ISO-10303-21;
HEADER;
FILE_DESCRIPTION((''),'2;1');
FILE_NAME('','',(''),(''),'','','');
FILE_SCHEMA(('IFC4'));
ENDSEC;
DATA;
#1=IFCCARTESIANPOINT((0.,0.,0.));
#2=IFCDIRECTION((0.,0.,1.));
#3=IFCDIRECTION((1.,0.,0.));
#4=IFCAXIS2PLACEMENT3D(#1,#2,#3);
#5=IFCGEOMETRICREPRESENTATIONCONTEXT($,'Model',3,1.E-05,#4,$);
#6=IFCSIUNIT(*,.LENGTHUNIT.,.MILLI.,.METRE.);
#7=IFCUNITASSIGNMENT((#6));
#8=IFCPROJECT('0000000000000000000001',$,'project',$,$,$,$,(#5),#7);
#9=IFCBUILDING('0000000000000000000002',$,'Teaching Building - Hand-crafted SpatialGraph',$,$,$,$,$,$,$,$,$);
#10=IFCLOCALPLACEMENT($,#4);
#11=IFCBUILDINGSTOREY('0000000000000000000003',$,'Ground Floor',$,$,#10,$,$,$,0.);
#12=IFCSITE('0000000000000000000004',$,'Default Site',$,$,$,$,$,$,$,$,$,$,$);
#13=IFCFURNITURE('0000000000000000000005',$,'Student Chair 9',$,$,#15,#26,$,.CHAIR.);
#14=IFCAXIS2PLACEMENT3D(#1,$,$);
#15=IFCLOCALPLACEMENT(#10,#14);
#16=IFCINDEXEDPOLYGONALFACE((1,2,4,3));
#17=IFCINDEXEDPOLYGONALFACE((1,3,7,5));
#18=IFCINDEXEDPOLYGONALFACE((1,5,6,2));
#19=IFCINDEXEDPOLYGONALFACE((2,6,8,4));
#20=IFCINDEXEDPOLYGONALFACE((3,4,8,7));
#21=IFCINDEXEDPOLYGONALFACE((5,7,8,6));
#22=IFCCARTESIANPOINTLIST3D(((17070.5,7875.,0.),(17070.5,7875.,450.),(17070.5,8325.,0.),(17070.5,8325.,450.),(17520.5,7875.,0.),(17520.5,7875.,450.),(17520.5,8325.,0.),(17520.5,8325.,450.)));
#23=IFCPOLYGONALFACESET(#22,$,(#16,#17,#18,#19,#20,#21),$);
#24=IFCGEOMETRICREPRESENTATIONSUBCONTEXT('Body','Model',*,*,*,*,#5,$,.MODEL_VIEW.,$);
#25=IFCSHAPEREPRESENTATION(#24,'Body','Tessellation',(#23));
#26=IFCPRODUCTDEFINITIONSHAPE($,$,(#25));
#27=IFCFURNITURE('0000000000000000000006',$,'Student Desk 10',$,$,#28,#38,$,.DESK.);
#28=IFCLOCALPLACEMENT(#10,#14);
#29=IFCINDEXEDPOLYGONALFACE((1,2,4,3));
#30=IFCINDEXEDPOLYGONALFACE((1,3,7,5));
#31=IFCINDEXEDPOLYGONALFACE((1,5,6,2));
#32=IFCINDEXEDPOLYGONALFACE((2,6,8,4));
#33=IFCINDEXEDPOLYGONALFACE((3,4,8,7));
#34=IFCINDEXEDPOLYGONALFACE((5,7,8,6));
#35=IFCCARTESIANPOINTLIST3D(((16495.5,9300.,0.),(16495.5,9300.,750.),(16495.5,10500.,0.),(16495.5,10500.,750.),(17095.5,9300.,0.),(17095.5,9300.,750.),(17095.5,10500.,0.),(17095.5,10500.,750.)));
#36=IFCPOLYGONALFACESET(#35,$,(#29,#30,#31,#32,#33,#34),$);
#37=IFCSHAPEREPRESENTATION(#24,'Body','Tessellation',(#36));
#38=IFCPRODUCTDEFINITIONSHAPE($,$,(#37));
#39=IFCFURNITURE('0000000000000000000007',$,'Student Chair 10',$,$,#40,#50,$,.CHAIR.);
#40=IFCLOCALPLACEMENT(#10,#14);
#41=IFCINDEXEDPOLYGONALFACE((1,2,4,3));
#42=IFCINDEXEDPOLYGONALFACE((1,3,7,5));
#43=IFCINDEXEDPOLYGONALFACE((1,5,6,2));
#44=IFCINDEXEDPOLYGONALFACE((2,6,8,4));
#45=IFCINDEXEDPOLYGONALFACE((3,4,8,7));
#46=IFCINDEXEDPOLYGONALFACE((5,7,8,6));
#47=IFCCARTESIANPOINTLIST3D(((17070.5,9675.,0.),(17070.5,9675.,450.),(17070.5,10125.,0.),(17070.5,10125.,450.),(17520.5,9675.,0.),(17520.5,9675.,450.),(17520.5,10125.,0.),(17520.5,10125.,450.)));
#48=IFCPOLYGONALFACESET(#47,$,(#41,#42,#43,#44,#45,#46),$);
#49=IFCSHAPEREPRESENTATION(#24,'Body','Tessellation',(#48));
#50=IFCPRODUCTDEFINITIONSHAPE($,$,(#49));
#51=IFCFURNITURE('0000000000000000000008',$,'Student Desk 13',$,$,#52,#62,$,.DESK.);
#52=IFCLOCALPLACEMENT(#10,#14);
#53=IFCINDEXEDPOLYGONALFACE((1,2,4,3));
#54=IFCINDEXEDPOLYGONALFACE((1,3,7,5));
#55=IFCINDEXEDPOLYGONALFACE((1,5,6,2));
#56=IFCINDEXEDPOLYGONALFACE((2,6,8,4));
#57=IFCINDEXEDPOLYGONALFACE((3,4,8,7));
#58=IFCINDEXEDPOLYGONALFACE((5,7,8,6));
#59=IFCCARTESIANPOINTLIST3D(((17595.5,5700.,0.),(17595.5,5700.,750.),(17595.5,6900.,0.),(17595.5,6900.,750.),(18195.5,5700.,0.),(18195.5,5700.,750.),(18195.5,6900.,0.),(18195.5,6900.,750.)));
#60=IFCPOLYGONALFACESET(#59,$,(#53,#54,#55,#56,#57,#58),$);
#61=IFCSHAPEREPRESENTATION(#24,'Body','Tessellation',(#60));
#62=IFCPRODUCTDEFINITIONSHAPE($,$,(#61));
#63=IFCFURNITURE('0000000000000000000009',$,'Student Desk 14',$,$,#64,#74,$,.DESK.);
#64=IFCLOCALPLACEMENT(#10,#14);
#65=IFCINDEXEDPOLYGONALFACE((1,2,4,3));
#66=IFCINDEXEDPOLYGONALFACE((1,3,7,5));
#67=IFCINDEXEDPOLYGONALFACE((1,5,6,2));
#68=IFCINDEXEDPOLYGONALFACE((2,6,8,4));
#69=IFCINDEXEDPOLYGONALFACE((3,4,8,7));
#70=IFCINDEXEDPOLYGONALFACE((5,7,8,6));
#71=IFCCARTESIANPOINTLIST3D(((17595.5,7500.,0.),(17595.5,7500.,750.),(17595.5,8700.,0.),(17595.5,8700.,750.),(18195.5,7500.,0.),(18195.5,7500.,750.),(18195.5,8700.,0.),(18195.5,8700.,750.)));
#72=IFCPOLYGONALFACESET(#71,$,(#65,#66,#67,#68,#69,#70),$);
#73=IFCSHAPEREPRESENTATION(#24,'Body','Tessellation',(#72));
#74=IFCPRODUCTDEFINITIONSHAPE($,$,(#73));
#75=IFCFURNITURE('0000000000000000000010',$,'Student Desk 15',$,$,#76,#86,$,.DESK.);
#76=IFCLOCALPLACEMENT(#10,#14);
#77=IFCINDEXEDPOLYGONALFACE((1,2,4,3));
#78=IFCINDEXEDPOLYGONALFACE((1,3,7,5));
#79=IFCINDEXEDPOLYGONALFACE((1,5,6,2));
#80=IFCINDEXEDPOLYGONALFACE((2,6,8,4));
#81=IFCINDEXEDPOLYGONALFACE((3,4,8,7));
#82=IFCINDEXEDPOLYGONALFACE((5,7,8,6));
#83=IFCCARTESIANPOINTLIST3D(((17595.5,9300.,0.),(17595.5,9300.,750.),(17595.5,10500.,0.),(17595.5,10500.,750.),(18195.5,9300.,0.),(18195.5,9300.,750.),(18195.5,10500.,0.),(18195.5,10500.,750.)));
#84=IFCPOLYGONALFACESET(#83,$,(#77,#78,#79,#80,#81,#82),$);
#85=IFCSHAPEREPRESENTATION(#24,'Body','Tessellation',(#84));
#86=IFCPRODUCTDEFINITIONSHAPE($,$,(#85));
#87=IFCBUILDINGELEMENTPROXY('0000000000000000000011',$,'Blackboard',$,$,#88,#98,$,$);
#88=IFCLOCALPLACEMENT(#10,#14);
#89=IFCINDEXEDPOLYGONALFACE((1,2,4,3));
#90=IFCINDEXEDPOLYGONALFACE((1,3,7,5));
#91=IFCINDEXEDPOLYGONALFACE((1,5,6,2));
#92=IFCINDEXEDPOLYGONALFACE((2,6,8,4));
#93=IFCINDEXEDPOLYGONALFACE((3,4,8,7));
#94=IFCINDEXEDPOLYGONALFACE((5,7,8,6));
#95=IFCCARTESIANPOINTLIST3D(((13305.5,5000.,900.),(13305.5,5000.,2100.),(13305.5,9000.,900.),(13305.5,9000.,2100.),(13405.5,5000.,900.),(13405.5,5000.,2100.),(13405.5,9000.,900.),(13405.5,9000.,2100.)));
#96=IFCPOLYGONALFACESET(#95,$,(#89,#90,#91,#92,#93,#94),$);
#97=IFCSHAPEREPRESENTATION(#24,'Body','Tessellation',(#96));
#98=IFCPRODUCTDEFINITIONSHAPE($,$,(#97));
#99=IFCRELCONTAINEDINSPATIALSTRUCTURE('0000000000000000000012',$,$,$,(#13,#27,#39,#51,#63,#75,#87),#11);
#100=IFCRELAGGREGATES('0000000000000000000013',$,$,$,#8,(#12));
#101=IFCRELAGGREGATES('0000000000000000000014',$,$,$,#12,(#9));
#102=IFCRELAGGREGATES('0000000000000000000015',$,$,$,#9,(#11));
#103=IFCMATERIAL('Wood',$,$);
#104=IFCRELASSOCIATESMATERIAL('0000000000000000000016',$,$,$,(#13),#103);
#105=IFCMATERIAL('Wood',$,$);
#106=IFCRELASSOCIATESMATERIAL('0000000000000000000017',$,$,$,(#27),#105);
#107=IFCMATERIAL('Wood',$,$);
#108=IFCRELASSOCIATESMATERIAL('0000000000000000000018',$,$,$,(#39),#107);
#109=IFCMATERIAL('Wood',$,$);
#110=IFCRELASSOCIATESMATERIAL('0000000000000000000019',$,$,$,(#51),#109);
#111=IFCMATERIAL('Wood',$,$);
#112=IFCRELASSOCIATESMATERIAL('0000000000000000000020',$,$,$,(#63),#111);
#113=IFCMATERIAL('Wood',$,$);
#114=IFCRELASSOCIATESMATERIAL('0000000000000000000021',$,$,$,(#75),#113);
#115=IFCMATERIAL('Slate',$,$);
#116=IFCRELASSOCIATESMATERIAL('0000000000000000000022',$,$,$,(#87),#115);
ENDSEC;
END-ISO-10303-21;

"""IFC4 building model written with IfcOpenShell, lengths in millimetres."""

from ifc_helpers import new_model, si_unit, frame, origin_with_axes, origin_2d, place, context, subcontext, project, spatial, rectangle, extrude, material, element, save


model = new_model("IFC4")

# Units and contexts
model_context = context("Model", 3, precision=1e-05, world=origin_with_axes())
body_context = subcontext(model_context, "Body", "Model", "MODEL_VIEW")
ifc_project = project(units=[si_unit("LENGTHUNIT", "METRE", prefix="MILLI")], contexts=[model_context])

# Site, building, storey
site = spatial("IfcSite", under=ifc_project, Name="Default Site")
building = spatial("IfcBuilding", under=site, Name="Teaching Building - Hand-crafted SpatialGraph")
storey_placement = place(None, origin_with_axes())
storey = spatial("IfcBuildingStorey", under=building, at=storey_placement, Name="Ground Floor", Elevation=0.0)

# Furniture
ifc_material_1 = material(Name="Wood")
furniture_1_placement = place(storey_placement, frame((17295.5, 8100.0, 0.0), z_axis=(0.0, 0.0, 1.0), x_axis=(1.0, 0.0, 0.0)))
element("IfcFurniture", 1, at=furniture_1_placement, inside=storey, material=ifc_material_1, Name="Student Chair 9", PredefinedType="CHAIR", context=body_context, shape_type="SweptSolid", body=[
    extrude(rectangle(XDim=450.0, YDim=450.0, at=origin_2d()), origin_with_axes(), (0.0, 0.0, 1.0), 450.0),
])
ifc_material_2 = material(Name="Wood")
furniture_2_placement = place(storey_placement, frame((16795.5, 9900.0, 0.0), z_axis=(0.0, 0.0, 1.0), x_axis=(0.0, 1.0, 0.0)))
element("IfcFurniture", 2, at=furniture_2_placement, inside=storey, material=ifc_material_2, Name="Student Desk 10", PredefinedType="DESK", context=body_context, shape_type="SweptSolid", body=[
    extrude(rectangle(XDim=1200.0, YDim=600.0, at=origin_2d()), origin_with_axes(), (0.0, 0.0, 1.0), 750.0),
])
ifc_material_3 = material(Name="Wood")
furniture_3_placement = place(storey_placement, frame((17295.5, 9900.0, 0.0), z_axis=(0.0, 0.0, 1.0), x_axis=(1.0, 0.0, 0.0)))
element("IfcFurniture", 3, at=furniture_3_placement, inside=storey, material=ifc_material_3, Name="Student Chair 10", PredefinedType="CHAIR", context=body_context, shape_type="SweptSolid", body=[
    extrude(rectangle(XDim=450.0, YDim=450.0, at=origin_2d()), origin_with_axes(), (0.0, 0.0, 1.0), 450.0),
])
ifc_material_4 = material(Name="Wood")
furniture_4_placement = place(storey_placement, frame((17895.5, 6300.0, 0.0), z_axis=(0.0, 0.0, 1.0), x_axis=(0.0, 1.0, 0.0)))
element("IfcFurniture", 4, at=furniture_4_placement, inside=storey, material=ifc_material_4, Name="Student Desk 13", PredefinedType="DESK", context=body_context, shape_type="SweptSolid", body=[
    extrude(rectangle(XDim=1200.0, YDim=600.0, at=origin_2d()), origin_with_axes(), (0.0, 0.0, 1.0), 750.0),
])
ifc_material_5 = material(Name="Wood")
furniture_5_placement = place(storey_placement, frame((17895.5, 8100.0, 0.0), z_axis=(0.0, 0.0, 1.0), x_axis=(0.0, 1.0, 0.0)))
element("IfcFurniture", 5, at=furniture_5_placement, inside=storey, material=ifc_material_5, Name="Student Desk 14", PredefinedType="DESK", context=body_context, shape_type="SweptSolid", body=[
    extrude(rectangle(XDim=1200.0, YDim=600.0, at=origin_2d()), origin_with_axes(), (0.0, 0.0, 1.0), 750.0),
])
ifc_material_6 = material(Name="Wood")
furniture_6_placement = place(storey_placement, frame((17895.5, 9900.0, 0.0), z_axis=(0.0, 0.0, 1.0), x_axis=(0.0, 1.0, 0.0)))
element("IfcFurniture", 6, at=furniture_6_placement, inside=storey, material=ifc_material_6, Name="Student Desk 15", PredefinedType="DESK", context=body_context, shape_type="SweptSolid", body=[
    extrude(rectangle(XDim=1200.0, YDim=600.0, at=origin_2d()), origin_with_axes(), (0.0, 0.0, 1.0), 750.0),
])

# Building element proxy
ifc_material_7 = material(Name="Slate")
proxy_placement = place(storey_placement, frame((13355.5, 7000.0, 900.0), z_axis=(0.0, 0.0, 1.0), x_axis=(1.0, 0.0, 0.0)))
element("IfcBuildingElementProxy", 7, at=proxy_placement, inside=storey, material=ifc_material_7, Name="Blackboard", context=body_context, shape_type="SweptSolid", body=[
    extrude(rectangle(XDim=100.0, YDim=4000.0, at=origin_2d()), origin_with_axes(), (0.0, 0.0, 1.0), 1200.0),
])

save(model, "model.ifc")
